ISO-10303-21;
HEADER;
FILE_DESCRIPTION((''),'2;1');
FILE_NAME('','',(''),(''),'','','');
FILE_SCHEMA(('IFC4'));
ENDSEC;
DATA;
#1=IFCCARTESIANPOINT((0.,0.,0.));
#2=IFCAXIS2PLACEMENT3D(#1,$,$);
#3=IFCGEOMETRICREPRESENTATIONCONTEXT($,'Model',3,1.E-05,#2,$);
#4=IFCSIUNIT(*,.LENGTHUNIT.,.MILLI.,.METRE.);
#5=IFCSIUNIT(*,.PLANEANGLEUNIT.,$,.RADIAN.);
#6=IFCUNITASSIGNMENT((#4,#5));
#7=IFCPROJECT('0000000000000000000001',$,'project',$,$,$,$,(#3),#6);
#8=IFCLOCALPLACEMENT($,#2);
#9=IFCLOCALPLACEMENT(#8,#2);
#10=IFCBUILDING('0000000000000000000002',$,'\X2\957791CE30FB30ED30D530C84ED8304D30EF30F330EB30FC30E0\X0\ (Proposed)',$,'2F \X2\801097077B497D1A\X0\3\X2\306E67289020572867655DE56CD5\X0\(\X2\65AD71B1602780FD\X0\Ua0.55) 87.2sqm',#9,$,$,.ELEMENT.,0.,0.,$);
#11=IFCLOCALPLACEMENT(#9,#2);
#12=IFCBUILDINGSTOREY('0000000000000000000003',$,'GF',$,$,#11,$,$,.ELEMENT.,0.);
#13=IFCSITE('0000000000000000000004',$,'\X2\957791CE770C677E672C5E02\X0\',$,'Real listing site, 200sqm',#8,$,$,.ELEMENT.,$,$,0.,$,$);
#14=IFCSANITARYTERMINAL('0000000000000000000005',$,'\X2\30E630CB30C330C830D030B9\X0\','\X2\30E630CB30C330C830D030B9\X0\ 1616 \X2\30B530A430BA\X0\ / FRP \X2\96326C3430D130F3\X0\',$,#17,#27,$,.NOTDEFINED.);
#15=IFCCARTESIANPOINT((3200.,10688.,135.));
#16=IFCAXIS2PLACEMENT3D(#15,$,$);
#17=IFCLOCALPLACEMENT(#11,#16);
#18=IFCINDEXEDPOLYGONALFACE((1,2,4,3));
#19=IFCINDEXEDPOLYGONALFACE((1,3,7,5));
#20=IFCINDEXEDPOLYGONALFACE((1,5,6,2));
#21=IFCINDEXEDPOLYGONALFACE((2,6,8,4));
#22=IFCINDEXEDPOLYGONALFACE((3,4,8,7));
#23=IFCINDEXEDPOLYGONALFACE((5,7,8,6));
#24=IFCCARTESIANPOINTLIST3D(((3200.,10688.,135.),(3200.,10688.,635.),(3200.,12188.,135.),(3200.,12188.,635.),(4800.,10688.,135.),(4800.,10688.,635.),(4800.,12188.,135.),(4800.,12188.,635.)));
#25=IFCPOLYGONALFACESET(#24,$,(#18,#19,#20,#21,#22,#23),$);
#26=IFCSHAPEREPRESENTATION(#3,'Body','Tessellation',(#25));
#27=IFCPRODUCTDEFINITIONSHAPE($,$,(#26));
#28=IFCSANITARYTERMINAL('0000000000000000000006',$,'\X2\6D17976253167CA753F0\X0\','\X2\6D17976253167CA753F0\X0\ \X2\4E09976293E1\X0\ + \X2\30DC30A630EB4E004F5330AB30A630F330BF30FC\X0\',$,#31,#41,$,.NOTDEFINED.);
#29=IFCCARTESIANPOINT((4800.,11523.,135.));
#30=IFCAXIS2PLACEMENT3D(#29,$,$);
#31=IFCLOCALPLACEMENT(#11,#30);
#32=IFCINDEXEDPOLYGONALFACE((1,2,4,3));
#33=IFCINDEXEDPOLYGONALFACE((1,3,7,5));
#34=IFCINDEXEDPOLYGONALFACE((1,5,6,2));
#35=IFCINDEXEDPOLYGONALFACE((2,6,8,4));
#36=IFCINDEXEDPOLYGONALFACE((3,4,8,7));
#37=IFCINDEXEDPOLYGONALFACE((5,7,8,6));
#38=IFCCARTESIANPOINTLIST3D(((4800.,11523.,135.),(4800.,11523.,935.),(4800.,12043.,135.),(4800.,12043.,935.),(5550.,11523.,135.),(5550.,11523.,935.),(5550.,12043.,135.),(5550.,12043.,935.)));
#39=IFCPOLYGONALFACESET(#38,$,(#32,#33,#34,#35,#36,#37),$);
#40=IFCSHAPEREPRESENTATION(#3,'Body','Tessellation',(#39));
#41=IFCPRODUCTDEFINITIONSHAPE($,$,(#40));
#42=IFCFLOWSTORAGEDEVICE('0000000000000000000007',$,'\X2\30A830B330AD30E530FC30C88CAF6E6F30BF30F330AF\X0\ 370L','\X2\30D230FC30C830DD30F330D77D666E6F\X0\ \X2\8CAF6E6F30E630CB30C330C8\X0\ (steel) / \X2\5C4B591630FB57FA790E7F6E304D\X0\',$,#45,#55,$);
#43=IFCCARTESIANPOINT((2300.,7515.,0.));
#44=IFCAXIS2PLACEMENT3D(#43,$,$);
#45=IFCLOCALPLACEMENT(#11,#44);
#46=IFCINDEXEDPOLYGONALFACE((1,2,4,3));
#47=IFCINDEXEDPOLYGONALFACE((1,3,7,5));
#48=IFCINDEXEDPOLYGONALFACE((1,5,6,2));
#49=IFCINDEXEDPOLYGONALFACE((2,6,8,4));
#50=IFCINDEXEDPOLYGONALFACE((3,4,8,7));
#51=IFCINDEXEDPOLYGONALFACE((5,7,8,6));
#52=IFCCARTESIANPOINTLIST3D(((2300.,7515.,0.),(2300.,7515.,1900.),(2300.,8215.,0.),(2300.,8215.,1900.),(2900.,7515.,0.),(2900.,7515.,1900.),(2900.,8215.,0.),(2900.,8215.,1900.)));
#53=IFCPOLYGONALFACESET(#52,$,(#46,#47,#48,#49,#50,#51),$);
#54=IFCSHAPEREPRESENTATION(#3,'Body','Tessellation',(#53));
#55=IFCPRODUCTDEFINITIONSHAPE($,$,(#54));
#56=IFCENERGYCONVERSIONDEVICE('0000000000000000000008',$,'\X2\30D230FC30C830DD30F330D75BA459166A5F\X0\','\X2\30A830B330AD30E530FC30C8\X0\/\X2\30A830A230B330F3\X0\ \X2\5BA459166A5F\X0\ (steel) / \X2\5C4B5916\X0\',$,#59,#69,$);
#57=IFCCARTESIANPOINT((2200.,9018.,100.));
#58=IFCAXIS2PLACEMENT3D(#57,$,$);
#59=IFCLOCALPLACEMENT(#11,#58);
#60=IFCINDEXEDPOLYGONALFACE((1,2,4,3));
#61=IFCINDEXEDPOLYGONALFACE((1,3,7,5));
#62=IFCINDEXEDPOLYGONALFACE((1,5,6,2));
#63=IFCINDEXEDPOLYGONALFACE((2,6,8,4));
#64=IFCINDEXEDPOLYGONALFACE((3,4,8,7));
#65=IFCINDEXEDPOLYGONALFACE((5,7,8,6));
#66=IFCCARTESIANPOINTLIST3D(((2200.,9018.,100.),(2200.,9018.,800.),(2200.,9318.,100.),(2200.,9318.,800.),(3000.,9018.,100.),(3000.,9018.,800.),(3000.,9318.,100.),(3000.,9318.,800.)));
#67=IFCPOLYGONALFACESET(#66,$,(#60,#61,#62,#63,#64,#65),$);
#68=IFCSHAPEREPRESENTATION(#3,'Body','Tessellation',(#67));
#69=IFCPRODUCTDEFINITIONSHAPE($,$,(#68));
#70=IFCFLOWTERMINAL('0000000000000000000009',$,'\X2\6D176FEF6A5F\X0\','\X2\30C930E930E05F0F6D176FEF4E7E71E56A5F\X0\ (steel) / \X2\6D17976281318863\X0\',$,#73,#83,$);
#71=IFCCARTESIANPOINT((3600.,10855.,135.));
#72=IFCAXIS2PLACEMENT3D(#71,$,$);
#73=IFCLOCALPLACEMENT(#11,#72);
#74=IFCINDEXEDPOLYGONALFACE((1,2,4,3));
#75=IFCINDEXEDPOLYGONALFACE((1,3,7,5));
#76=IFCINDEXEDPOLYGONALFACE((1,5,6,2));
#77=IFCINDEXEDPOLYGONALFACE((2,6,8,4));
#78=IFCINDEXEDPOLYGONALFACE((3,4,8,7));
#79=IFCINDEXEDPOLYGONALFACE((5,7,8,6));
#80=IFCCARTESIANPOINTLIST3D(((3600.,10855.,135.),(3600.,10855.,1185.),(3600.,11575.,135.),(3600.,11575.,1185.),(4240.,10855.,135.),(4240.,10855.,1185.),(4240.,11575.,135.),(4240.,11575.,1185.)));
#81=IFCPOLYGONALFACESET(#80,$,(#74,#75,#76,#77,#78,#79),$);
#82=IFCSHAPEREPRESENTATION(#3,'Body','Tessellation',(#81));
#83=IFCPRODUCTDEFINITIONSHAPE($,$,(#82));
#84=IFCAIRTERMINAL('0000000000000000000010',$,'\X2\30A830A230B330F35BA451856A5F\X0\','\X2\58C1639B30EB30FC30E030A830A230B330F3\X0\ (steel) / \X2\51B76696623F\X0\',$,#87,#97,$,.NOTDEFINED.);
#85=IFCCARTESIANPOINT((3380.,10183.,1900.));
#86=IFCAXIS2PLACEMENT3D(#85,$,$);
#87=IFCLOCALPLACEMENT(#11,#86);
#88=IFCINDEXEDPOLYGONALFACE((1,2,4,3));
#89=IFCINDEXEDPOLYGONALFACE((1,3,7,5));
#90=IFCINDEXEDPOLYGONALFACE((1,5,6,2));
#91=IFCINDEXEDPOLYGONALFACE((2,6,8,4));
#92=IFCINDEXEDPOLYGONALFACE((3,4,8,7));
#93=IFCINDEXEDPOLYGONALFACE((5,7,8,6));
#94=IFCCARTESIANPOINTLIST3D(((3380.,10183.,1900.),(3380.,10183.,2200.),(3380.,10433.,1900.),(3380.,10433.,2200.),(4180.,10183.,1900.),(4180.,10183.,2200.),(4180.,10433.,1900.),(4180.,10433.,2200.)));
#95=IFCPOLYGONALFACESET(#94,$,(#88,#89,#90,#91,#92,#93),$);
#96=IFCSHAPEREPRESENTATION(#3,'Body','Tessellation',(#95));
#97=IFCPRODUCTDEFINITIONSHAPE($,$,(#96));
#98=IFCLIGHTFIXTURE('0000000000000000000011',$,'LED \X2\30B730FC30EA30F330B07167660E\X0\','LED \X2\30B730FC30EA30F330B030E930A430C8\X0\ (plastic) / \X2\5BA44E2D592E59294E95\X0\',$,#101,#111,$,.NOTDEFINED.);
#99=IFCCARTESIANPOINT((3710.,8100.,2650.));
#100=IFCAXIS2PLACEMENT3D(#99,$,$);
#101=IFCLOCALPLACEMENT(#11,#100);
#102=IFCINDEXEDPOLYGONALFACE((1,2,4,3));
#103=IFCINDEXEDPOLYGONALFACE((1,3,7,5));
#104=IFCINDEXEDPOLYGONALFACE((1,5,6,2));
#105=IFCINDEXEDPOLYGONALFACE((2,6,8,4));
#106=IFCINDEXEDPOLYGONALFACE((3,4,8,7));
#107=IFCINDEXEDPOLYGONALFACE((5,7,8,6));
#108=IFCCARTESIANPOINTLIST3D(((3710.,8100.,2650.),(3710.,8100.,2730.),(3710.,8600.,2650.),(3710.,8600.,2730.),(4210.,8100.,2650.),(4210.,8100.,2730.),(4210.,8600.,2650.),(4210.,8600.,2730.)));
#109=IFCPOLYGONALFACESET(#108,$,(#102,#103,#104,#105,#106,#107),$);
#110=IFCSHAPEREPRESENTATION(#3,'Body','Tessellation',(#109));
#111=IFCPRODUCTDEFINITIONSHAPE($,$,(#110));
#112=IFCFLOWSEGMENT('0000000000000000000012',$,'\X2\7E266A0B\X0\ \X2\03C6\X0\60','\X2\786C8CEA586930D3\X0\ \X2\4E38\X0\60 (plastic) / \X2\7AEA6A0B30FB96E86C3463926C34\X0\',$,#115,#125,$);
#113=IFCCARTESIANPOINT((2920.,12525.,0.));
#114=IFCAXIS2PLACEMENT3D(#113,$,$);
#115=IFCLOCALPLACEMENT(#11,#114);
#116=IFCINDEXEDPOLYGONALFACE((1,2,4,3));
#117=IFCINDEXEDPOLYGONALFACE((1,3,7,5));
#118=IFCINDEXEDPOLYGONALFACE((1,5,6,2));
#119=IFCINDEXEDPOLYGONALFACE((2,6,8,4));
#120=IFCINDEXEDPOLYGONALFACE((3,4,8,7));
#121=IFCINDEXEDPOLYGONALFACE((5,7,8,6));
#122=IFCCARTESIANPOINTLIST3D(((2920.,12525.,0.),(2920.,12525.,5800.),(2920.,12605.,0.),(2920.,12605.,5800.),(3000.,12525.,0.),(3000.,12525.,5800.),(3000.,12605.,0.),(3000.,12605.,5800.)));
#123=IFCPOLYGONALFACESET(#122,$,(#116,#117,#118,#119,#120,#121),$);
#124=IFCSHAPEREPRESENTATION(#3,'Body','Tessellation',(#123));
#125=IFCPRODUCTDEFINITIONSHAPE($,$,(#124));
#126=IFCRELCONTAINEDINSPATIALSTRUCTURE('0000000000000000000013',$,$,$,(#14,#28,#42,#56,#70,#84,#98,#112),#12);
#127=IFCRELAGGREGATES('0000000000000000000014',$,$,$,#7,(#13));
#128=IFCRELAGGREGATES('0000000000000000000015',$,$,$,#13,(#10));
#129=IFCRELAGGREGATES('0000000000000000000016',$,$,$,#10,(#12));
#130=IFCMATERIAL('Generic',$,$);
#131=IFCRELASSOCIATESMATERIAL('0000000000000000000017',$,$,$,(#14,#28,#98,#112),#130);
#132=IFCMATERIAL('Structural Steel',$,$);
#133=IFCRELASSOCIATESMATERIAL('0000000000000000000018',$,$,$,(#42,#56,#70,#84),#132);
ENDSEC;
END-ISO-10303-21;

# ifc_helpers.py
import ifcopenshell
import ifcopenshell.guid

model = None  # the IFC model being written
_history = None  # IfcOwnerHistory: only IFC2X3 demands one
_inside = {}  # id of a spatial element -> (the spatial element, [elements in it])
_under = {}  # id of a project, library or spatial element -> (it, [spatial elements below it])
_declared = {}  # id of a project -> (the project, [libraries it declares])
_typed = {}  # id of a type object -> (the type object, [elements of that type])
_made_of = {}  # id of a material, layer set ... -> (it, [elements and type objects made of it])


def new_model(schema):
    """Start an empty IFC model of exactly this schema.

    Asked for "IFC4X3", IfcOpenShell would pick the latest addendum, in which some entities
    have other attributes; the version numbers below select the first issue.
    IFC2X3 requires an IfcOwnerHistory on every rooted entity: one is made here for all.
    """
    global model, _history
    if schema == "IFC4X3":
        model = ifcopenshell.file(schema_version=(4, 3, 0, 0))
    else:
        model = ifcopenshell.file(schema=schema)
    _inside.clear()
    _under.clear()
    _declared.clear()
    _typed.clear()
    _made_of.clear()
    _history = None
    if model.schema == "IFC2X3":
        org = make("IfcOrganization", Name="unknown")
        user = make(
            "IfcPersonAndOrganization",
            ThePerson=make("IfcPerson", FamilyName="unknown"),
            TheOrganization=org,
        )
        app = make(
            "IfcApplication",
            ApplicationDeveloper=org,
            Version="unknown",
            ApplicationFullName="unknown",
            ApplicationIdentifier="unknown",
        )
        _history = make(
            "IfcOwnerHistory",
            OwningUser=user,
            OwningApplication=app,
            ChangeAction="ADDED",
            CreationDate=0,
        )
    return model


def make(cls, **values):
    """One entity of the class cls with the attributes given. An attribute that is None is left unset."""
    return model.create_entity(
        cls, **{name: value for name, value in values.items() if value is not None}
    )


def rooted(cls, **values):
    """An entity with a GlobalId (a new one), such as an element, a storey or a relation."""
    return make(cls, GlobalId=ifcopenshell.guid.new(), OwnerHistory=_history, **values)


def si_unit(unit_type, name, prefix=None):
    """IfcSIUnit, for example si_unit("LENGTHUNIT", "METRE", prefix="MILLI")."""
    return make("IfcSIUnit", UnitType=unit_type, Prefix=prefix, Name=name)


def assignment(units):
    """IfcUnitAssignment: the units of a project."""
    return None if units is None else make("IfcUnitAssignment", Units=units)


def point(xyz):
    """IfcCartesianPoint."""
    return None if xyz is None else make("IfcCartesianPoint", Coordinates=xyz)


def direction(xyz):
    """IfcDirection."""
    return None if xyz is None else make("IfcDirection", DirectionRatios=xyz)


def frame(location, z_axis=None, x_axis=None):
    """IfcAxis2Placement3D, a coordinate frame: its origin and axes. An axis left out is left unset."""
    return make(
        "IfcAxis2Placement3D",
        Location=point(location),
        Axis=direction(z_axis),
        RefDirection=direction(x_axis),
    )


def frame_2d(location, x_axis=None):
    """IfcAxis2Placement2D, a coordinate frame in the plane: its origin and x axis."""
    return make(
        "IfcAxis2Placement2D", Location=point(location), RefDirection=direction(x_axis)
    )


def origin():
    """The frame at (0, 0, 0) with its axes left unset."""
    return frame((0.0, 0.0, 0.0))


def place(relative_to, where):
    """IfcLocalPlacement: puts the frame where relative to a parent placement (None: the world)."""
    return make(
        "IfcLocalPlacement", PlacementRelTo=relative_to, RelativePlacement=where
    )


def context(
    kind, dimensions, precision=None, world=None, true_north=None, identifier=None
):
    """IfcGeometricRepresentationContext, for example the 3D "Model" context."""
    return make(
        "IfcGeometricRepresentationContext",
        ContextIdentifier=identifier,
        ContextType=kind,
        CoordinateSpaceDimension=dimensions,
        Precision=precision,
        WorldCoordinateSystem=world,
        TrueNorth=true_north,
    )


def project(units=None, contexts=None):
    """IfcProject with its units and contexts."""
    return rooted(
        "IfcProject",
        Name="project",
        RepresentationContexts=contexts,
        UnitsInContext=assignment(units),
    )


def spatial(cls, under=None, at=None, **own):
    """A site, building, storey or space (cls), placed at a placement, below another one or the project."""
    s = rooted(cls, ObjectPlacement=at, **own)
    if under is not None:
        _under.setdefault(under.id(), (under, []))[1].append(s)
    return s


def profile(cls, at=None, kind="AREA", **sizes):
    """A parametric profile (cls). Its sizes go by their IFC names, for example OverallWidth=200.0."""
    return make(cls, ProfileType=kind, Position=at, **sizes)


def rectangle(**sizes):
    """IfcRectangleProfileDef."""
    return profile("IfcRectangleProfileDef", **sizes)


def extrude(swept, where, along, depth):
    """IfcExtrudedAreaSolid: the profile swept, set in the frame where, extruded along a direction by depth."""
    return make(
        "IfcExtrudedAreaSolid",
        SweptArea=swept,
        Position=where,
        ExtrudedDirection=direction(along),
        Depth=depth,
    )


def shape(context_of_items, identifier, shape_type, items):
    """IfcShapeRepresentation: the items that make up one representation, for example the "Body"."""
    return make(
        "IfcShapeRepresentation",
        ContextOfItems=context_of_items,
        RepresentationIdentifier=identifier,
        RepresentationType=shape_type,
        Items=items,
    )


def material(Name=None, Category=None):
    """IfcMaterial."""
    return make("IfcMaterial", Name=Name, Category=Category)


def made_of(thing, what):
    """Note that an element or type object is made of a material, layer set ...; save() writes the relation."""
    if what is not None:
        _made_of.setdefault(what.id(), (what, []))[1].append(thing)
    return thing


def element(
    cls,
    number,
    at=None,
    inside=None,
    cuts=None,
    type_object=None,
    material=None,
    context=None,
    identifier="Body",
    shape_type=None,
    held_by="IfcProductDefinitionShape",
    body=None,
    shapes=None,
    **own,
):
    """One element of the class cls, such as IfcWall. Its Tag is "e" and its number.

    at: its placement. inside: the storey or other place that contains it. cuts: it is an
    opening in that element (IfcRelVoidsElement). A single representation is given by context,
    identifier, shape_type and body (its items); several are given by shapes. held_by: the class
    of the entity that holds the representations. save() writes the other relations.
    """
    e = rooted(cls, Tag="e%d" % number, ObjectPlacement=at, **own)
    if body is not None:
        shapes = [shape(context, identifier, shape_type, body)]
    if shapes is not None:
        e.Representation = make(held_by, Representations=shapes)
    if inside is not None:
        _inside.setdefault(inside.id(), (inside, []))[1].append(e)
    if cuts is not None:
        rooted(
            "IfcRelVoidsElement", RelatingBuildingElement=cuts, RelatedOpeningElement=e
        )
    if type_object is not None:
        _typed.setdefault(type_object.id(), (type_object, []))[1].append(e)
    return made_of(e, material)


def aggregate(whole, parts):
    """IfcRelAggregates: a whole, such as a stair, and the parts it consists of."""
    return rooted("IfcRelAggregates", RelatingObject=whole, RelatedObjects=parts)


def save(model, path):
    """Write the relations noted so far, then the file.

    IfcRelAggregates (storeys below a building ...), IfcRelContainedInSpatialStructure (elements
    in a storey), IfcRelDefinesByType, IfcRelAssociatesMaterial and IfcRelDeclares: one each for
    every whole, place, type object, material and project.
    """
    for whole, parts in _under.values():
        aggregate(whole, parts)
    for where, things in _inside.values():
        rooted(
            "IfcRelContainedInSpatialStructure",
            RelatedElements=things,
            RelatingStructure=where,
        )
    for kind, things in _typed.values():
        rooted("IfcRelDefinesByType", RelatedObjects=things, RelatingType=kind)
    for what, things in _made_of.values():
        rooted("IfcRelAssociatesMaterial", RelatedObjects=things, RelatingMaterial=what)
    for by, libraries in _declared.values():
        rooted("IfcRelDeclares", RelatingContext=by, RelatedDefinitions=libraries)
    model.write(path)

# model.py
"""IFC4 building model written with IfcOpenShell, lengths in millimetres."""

from ifc_helpers import new_model, si_unit, frame, frame_2d, origin, place, context, project, spatial, rectangle, extrude, material, element, save


model = new_model("IFC4")

# Units and contexts
model_context = context("Model", 3, precision=1e-05, world=origin())
ifc_project = project(units=[si_unit("LENGTHUNIT", "METRE", prefix="MILLI"), si_unit("PLANEANGLEUNIT", "RADIAN")], contexts=[model_context])

# Site, building, storey
site_placement = place(None, origin())
site = spatial("IfcSite", under=ifc_project, at=site_placement, Name="長野県松本市", ObjectType="Real listing site, 200sqm", CompositionType="ELEMENT", RefElevation=0.0)
building_placement = place(site_placement, origin())
building = spatial("IfcBuilding", under=site, at=building_placement, Name="長野・ロフト付きワンルーム (Proposed)", ObjectType="2F 耐震等級3の木造在来工法(断熱性能Ua0.55) 87.2sqm", CompositionType="ELEMENT", ElevationOfRefHeight=0.0, ElevationOfTerrain=0.0)
storey_placement = place(building_placement, origin())
storey = spatial("IfcBuildingStorey", under=building, at=storey_placement, Name="GF", CompositionType="ELEMENT", Elevation=0.0)

# Shared definitions
ifc_material_1 = material(Name="Generic")

# Sanitary terminals
sanitary_terminal_1_placement = place(storey_placement, frame((3200.0, 10688.0, 135.0)))
element("IfcSanitaryTerminal", 1, at=sanitary_terminal_1_placement, inside=storey, material=ifc_material_1, Name="ユニットバス", Description="ユニットバス 1616 サイズ / FRP 防水パン", PredefinedType="NOTDEFINED", context=model_context, shape_type="SweptSolid", body=[
    extrude(rectangle(XDim=1600.0, YDim=1500.0, at=frame_2d((800.0, 750.0))), frame((3200.0, 10688.0, 135.0)), (0.0, 0.0, 1.0), 500.0),
])
sanitary_terminal_2_placement = place(storey_placement, frame((4800.0, 11523.0, 135.0)))
element("IfcSanitaryTerminal", 2, at=sanitary_terminal_2_placement, inside=storey, material=ifc_material_1, Name="洗面化粧台", Description="洗面化粧台 三面鏡 + ボウル一体カウンター", PredefinedType="NOTDEFINED", context=model_context, shape_type="SweptSolid", body=[
    extrude(rectangle(XDim=750.0, YDim=520.0, at=frame_2d((375.0, 260.0))), frame((4800.0, 11523.0, 135.0)), (0.0, 0.0, 1.0), 800.0),
])

# Flow storage device
ifc_material_2 = material(Name="Structural Steel")
flow_storage_device_placement = place(storey_placement, frame((2300.0, 7515.0, 0.0)))
element("IfcFlowStorageDevice", 3, at=flow_storage_device_placement, inside=storey, material=ifc_material_2, Name="エコキュート貯湯タンク 370L", Description="ヒートポンプ給湯 貯湯ユニット (steel) / 屋外・基礎置き", context=model_context, shape_type="SweptSolid", body=[
    extrude(rectangle(XDim=600.0, YDim=700.0, at=frame_2d((300.0, 350.0))), frame((2300.0, 7515.0, 0.0)), (0.0, 0.0, 1.0), 1900.0),
])

# Energy conversion device
energy_conversion_device_placement = place(storey_placement, frame((2200.0, 9018.0, 100.0)))
element("IfcEnergyConversionDevice", 4, at=energy_conversion_device_placement, inside=storey, material=ifc_material_2, Name="ヒートポンプ室外機", Description="エコキュート/エアコン 室外機 (steel) / 屋外", context=model_context, shape_type="SweptSolid", body=[
    extrude(rectangle(XDim=800.0, YDim=300.0, at=frame_2d((400.0, 150.0))), frame((2200.0, 9018.0, 100.0)), (0.0, 0.0, 1.0), 700.0),
])

# Flow terminal
flow_terminal_placement = place(storey_placement, frame((3600.0, 10855.0, 135.0)))
element("IfcFlowTerminal", 5, at=flow_terminal_placement, inside=storey, material=ifc_material_2, Name="洗濯機", Description="ドラム式洗濯乾燥機 (steel) / 洗面脱衣", context=model_context, shape_type="SweptSolid", body=[
    extrude(rectangle(XDim=640.0, YDim=720.0, at=frame_2d((320.0, 360.0))), frame((3600.0, 10855.0, 135.0)), (0.0, 0.0, 1.0), 1050.0),
])

# Air terminal
air_terminal_placement = place(storey_placement, frame((3380.0, 10183.0, 1900.0)))
element("IfcAirTerminal", 6, at=air_terminal_placement, inside=storey, material=ifc_material_2, Name="エアコン室内機", Description="壁掛ルームエアコン (steel) / 冷暖房", PredefinedType="NOTDEFINED", context=model_context, shape_type="SweptSolid", body=[
    extrude(rectangle(XDim=800.0, YDim=250.0, at=frame_2d((400.0, 125.0))), frame((3380.0, 10183.0, 1900.0)), (0.0, 0.0, 1.0), 300.0),
])

# Light fixture
light_fixture_placement = place(storey_placement, frame((3710.0, 8100.0, 2650.0)))
element("IfcLightFixture", 7, at=light_fixture_placement, inside=storey, material=ifc_material_1, Name="LED シーリング照明", Description="LED シーリングライト (plastic) / 室中央天井", PredefinedType="NOTDEFINED", context=model_context, shape_type="SweptSolid", body=[
    extrude(rectangle(XDim=500.0, YDim=500.0, at=frame_2d((250.0, 250.0))), frame((3710.0, 8100.0, 2650.0)), (0.0, 0.0, 1.0), 80.0),
])

# Flow segment
flow_segment_placement = place(storey_placement, frame((2920.0, 12525.0, 0.0)))
element("IfcFlowSegment", 8, at=flow_segment_placement, inside=storey, material=ifc_material_1, Name="縦樋 φ60", Description="硬質塩ビ 丸60 (plastic) / 竪樋・雨水排水", context=model_context, shape_type="SweptSolid", body=[
    extrude(rectangle(XDim=80.0, YDim=80.0, at=frame_2d((40.0, 40.0))), frame((2920.0, 12525.0, 0.0)), (0.0, 0.0, 1.0), 5800.0),
])

save(model, "model.ifc")
